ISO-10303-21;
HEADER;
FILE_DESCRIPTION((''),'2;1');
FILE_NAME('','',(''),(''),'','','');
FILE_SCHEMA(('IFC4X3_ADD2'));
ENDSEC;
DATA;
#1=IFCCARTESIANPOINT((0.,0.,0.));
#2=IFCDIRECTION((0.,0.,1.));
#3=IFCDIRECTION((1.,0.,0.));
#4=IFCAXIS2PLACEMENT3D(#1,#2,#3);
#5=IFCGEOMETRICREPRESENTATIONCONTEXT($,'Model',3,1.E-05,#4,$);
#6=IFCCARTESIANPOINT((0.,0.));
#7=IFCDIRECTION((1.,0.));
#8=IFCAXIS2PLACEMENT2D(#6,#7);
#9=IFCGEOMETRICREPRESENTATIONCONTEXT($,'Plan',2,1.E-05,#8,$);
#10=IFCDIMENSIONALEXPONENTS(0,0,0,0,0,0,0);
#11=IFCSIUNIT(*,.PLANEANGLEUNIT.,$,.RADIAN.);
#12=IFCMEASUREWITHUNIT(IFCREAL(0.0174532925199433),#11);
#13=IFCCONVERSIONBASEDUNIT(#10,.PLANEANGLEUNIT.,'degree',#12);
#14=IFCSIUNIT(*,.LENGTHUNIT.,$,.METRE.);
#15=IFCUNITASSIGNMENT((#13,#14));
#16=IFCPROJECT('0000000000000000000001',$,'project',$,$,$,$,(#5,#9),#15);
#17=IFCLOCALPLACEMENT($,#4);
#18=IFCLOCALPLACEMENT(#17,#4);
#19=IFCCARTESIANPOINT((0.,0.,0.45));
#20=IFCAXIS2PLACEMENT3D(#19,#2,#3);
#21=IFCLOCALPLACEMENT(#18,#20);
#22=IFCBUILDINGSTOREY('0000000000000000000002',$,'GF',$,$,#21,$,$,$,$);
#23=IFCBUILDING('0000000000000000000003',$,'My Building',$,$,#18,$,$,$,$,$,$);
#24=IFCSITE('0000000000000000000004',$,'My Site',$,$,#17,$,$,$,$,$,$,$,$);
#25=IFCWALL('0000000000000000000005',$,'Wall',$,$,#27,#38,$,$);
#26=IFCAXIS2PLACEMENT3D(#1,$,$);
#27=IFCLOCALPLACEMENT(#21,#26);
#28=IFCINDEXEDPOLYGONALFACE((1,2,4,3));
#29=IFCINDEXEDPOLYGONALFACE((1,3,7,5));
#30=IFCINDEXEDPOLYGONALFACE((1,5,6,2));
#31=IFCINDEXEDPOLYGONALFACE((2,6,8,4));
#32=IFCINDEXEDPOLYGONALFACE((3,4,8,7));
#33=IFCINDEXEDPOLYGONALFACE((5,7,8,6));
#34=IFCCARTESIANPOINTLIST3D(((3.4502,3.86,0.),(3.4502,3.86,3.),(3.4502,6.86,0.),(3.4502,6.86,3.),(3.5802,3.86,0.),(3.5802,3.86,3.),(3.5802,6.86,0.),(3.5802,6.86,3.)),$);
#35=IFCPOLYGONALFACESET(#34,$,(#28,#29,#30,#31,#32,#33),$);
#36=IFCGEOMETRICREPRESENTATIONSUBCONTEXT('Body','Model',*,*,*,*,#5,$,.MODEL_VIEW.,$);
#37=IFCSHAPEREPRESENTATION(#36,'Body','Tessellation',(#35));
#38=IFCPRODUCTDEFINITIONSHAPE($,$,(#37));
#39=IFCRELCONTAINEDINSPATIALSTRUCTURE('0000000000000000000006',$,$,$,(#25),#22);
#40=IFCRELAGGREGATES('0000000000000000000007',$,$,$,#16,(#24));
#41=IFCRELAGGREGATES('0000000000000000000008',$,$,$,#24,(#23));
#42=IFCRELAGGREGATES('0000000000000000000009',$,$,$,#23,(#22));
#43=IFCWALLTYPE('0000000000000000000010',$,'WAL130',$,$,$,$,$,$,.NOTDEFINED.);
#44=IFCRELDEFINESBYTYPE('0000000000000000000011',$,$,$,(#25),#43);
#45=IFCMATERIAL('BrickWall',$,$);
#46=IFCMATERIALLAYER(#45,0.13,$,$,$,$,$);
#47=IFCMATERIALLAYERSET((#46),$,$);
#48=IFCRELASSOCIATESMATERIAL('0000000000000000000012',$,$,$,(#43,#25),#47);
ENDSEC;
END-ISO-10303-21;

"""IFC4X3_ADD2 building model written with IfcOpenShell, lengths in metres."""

from ifc_helpers import new_model, entity, si_unit, converted_unit, frame, origin_with_axes, origin_2d_with_axis, place, context, subcontext, project, spatial, indexed_curve, outline, extrude, material, layer, layer_set, layer_usage, type_object, element, save


model = new_model("IFC4X3_ADD2")

# Units and contexts
model_context = context("Model", 3, precision=1e-05, world=origin_with_axes())
plan_context = context("Plan", 2, precision=1e-05, world=origin_2d_with_axis())
body_context_1 = subcontext(model_context, "Body", "Model", "MODEL_VIEW")
ifc_project = project(units=[converted_unit("PLANEANGLEUNIT", "degree", entity("IfcReal", 0.0174532925199433), si_unit("PLANEANGLEUNIT", "RADIAN"), dimensions=[0, 0, 0, 0, 0, 0, 0]), si_unit("LENGTHUNIT", "METRE")], contexts=[model_context, plan_context])

# Site, building, storey
site_placement = place(None, origin_with_axes())
site = spatial("IfcSite", under=ifc_project, at=site_placement, Name="My Site")
building_placement = place(site_placement, origin_with_axes())
building = spatial("IfcBuilding", under=site, at=building_placement, Name="My Building")
storey_placement = place(building_placement, frame((0.0, 0.0, 0.45), z_axis=(0.0, 0.0, 1.0), x_axis=(1.0, 0.0, 0.0)))
storey = spatial("IfcBuildingStorey", under=building, at=storey_placement, Name="GF")

# Shared definitions
ifc_material_1 = material(Name="BrickWall")

# Shared definitions
ifc_layer_1 = layer(ifc_material_1, 0.13)
ifc_layer_set_1 = layer_set([ifc_layer_1])
wall_type_1 = type_object("IfcWallType", Name="WAL130", PredefinedType="NOTDEFINED", material=ifc_layer_set_1)

# Wall
ifc_layer_usage_1 = layer_usage(ifc_layer_set_1, "AXIS2", "POSITIVE", 0.0)
wall_1_placement = place(storey_placement, frame((3.5802, 3.86, 0.0), z_axis=(0.0, 0.0, 1.0), x_axis=(0.0, 1.0, 0.0)))
element("IfcWall", 1, at=wall_1_placement, inside=storey, type_object=wall_type_1, material=ifc_layer_usage_1, Name="Wall", context=body_context_1, shape_type="SweptSolid", body=[
    extrude(outline(indexed_curve([(0.0, 0.0), (0.0, 0.13), (3.0, 0.13), (3.0, 0.0), (0.0, 0.0)], self_intersect=False)), origin_with_axes(), (0.0, 0.0, 1.0), 3.0),
])

save(model, "model.ifc")
